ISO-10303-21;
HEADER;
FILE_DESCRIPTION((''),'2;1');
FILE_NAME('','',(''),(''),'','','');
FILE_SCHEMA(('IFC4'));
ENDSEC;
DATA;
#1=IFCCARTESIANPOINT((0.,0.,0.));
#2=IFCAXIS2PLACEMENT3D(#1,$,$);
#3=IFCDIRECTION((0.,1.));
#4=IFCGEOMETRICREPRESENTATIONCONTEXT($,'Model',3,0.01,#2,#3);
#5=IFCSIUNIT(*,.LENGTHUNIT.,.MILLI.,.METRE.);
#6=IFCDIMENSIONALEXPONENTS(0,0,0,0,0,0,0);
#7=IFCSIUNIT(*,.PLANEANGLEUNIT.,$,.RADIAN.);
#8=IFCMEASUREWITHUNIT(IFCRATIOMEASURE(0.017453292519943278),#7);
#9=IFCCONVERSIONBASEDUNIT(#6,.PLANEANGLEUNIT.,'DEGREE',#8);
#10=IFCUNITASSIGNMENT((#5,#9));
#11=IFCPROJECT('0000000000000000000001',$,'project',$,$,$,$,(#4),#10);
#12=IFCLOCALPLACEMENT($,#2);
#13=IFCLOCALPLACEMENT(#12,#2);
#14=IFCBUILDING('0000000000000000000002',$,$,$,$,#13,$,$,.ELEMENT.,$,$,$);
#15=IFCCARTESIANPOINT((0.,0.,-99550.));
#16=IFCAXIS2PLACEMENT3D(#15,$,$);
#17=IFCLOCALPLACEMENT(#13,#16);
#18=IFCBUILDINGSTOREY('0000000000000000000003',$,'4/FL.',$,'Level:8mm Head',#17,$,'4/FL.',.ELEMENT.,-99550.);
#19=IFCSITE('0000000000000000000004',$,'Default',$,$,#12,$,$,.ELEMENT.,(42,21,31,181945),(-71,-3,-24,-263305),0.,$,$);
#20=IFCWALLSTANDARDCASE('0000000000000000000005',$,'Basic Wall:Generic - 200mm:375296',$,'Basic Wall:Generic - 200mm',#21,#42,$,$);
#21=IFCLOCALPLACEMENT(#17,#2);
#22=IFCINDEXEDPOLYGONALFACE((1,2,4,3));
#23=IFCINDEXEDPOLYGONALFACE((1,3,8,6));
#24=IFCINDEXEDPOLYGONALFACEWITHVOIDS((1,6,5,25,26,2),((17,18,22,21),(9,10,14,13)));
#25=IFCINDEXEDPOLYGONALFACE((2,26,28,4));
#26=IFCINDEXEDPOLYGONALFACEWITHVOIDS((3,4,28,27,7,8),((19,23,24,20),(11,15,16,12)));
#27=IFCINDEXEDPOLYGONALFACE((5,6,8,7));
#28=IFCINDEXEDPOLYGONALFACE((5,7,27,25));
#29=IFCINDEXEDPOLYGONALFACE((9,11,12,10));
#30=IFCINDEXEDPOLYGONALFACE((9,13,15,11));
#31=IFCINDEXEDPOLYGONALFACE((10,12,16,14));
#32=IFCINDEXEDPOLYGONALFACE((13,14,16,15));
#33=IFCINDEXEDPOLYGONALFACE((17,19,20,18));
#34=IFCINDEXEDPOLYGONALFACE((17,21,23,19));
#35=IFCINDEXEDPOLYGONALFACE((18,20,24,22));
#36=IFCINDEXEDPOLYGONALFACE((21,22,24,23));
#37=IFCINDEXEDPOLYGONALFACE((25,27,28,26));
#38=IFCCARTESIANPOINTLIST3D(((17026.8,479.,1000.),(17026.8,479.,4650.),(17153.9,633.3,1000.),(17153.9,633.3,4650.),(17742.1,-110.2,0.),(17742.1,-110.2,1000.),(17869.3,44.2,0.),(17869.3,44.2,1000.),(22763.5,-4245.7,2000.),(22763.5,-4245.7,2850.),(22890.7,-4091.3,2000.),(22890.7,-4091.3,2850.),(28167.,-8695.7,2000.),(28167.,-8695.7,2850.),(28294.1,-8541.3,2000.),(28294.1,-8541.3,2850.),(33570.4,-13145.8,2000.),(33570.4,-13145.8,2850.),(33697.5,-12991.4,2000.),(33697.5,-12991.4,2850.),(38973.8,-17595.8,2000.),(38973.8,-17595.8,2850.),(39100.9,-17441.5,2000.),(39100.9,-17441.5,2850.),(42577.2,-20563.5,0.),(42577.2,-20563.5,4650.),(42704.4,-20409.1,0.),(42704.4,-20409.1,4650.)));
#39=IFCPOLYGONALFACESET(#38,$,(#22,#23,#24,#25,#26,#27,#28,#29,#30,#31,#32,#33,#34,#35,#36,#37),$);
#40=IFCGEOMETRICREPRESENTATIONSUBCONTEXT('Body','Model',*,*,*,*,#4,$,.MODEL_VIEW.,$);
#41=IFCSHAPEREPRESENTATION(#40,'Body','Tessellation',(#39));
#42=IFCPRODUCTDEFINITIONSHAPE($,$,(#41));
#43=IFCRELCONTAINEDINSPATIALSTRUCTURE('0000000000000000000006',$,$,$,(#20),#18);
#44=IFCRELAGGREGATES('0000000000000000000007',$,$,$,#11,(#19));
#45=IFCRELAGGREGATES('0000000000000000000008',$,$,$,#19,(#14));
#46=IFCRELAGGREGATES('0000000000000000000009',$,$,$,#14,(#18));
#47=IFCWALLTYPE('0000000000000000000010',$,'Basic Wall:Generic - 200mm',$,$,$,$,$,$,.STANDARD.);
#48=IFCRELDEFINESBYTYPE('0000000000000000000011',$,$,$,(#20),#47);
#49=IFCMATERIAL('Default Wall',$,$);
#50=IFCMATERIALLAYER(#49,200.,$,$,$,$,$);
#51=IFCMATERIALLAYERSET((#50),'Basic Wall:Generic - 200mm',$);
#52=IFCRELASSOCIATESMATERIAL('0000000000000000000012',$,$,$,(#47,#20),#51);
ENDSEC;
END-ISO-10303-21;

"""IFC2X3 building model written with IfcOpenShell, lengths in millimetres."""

from ifc_helpers import new_model, entity, si_unit, converted_unit, direction, frame, frame_2d, origin, place, context, subcontext, project, spatial, rectangle, extrude, material, layer, layer_set, layer_usage, type_object, element, save


model = new_model("IFC2X3")

# Units and contexts
model_context = context("Model", 3, precision=0.01, world=origin(), true_north=direction((0.0, 1.0)))
body_context = subcontext(model_context, "Body", "Model", "MODEL_VIEW")
ifc_project = project(units=[si_unit("LENGTHUNIT", "METRE", prefix="MILLI"), converted_unit("PLANEANGLEUNIT", "DEGREE", entity("IfcRatioMeasure", 0.017453292519943278), si_unit("PLANEANGLEUNIT", "RADIAN"), dimensions=[0, 0, 0, 0, 0, 0, 0])], contexts=[model_context])

# Site, building, storey
site_placement = place(None, origin())
site = spatial("IfcSite", under=ifc_project, at=site_placement, Name="Default", CompositionType="ELEMENT", RefLatitude=(42, 21, 31, 181945), RefLongitude=(-71, -3, -24, -263305), RefElevation=0.0)
building_placement = place(site_placement, origin())
building = spatial("IfcBuilding", under=site, at=building_placement, CompositionType="ELEMENT")
storey_placement = place(building_placement, frame((0.0, 0.0, -99550.0)))
storey = spatial("IfcBuildingStorey", under=building, at=storey_placement, Name="4/FL.", ObjectType="Level:8mm Head", LongName="4/FL.", CompositionType="ELEMENT", Elevation=-99550.0)

# Wall, openings
ifc_material_1 = material(Name="Default Wall")
ifc_layer = layer(ifc_material_1, 200.0)
ifc_layer_set = layer_set([ifc_layer], Name="Basic Wall:Generic - 200mm")
ifc_layer_usage = layer_usage(ifc_layer_set, "AXIS2", "NEGATIVE", 100.0)
wall_type = type_object("IfcWallType", Name="Basic Wall:Generic - 200mm", PredefinedType="STANDARD", material=ifc_layer_set)
wall_1_placement = place(storey_placement, frame((42640.8, -20486.3, 0.0), z_axis=(0.0, 0.0, 1.0), x_axis=(-0.771917, 0.635723, 0.0)))
wall_1 = element("IfcWallStandardCase", 1, at=wall_1_placement, inside=storey, type_object=wall_type, material=ifc_layer_usage, Name="Basic Wall:Generic - 200mm:375296", ObjectType="Basic Wall:Generic - 200mm", context=body_context, shape_type="SweptSolid", body=[
    extrude(rectangle(XDim=33100.0, YDim=200.0, at=frame_2d((16550.0, 0.0), x_axis=(-1.0, 0.0))), origin(), (0.0, 0.0, 1.0), 4650.0),
])
opening_1_placement = place(wall_1_placement, origin())
element("IfcOpeningElement", 2, at=opening_1_placement, cuts=wall_1, ObjectType="Opening", context=body_context, shape_type="SweptSolid", body=[
    extrude(rectangle(XDim=850.0, YDim=7000.0, at=frame_2d((0.0, 0.0), x_axis=(1.0, 0.0))), frame((8168.1, -100.0, 2425.0), z_axis=(0.0, 1.0, 0.0), x_axis=(0.0, 0.0, -1.0)), (0.0, 0.0, 1.0), 200.0),
])
opening_2_placement = place(wall_1_placement, origin())
element("IfcOpeningElement", 3, at=opening_2_placement, cuts=wall_1, ObjectType="Opening", context=body_context, shape_type="SweptSolid", body=[
    extrude(rectangle(XDim=850.0, YDim=7000.0, at=frame_2d((0.0, 0.0), x_axis=(1.0, 0.0))), frame((22168.1, -100.0, 2425.0), z_axis=(0.0, 1.0, 0.0), x_axis=(0.0, 0.0, -1.0)), (0.0, 0.0, 1.0), 200.0),
])
opening_3_placement = place(wall_1_placement, frame((45938.8, 11294.0, 0.0), z_axis=(0.0, 0.0, 1.0), x_axis=(-0.771917, -0.635723, 0.0)))
element("IfcOpeningElement", 4, at=opening_3_placement, cuts=wall_1, ObjectType="Opening", context=body_context, shape_type="SweptSolid", body=[
    extrude(rectangle(XDim=1000.0, YDim=1010.1, at=frame_2d((0.0, 0.0), x_axis=(1.0, 0.0))), frame((17487.5, 375.1, 500.0), z_axis=(-0.635723, -0.771917, 0.0), x_axis=(0.0, 0.0, -1.0)), (0.0, 0.0, 1.0), 1012.7),
])

save(model, "model.ifc")
